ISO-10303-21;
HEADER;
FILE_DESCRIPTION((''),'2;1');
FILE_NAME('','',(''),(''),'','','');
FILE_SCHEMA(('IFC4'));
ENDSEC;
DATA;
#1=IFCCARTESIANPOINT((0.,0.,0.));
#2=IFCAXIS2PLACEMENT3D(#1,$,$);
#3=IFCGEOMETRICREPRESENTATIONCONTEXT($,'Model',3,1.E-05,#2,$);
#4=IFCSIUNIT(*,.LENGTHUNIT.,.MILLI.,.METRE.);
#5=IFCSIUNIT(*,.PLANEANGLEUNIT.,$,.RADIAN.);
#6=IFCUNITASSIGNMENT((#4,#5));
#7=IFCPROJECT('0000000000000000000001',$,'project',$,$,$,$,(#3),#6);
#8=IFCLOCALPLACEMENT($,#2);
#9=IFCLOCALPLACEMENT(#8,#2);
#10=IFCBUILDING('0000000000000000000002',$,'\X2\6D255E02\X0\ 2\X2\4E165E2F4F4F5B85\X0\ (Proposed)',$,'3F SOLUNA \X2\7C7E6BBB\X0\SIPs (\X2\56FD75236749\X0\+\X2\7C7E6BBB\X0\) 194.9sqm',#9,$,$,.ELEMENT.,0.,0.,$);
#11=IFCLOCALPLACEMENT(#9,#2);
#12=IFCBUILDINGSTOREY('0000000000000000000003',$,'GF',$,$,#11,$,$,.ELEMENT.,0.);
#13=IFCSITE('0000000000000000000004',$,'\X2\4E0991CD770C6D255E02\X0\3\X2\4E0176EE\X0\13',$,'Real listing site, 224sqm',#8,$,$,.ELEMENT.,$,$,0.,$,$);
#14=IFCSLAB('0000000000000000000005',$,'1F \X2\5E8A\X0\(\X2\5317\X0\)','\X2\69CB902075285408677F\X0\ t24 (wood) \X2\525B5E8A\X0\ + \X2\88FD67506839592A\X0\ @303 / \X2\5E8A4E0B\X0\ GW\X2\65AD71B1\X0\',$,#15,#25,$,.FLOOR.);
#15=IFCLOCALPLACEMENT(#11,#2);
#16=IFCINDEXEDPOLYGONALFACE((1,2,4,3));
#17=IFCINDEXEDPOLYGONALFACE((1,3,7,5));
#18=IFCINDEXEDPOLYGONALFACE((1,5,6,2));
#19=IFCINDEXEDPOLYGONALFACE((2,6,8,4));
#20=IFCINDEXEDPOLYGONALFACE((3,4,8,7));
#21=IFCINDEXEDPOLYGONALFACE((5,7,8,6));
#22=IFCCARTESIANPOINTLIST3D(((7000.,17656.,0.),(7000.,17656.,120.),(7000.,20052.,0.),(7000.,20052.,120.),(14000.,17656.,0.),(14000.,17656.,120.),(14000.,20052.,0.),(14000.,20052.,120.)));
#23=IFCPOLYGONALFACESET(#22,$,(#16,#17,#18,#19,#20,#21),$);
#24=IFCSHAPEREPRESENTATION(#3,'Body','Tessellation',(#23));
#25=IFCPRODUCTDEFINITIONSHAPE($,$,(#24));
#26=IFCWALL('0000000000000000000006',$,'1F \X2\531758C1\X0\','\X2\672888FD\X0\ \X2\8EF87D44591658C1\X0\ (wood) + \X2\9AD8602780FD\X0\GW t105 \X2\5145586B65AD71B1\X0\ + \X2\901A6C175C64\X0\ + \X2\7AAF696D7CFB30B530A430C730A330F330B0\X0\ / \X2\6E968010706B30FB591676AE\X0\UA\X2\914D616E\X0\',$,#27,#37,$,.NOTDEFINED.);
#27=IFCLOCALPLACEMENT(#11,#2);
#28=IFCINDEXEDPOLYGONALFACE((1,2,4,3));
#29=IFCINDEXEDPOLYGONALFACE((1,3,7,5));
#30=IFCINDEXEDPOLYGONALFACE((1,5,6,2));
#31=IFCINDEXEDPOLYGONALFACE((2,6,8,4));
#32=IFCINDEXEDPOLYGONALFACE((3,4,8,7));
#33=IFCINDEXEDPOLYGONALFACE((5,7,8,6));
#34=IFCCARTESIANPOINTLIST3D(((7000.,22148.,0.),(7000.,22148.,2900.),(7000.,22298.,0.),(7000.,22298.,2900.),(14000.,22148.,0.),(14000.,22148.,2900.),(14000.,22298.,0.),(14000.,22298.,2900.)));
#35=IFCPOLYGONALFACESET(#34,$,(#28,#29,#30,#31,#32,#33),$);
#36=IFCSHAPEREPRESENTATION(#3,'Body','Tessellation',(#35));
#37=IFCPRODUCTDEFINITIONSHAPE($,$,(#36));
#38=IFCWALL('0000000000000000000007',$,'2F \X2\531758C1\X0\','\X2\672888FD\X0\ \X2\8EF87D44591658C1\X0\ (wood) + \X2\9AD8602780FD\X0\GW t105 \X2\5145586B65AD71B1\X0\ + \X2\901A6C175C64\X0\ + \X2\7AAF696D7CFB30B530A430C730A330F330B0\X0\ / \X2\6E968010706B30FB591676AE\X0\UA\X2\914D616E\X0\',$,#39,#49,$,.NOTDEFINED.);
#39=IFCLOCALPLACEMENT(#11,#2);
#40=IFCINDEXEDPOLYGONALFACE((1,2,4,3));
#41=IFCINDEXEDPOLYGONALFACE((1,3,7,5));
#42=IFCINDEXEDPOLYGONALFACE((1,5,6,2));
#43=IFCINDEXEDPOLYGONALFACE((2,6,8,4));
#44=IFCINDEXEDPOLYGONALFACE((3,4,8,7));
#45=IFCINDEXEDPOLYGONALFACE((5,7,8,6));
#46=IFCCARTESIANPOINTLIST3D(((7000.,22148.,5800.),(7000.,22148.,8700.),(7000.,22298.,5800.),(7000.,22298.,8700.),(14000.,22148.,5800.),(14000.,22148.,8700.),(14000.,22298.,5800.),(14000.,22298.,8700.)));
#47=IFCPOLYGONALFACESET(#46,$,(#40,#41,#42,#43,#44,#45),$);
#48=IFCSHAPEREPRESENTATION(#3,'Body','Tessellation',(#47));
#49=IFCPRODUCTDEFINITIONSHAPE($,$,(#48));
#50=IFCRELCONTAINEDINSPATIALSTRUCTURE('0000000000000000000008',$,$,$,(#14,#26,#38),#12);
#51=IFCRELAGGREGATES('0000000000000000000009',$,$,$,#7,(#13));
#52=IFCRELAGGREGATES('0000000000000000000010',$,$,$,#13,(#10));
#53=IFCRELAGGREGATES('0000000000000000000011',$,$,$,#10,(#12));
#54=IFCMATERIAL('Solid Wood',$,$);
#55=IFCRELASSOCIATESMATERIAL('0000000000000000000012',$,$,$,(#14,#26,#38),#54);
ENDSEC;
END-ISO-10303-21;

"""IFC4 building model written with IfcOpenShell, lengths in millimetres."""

from ifc_helpers import new_model, si_unit, frame, frame_2d, origin, place, context, project, spatial, rectangle, extrude, material, element, save


model = new_model("IFC4")

# Units and contexts
model_context = context("Model", 3, precision=1e-05, world=origin())
ifc_project = project(units=[si_unit("LENGTHUNIT", "METRE", prefix="MILLI"), si_unit("PLANEANGLEUNIT", "RADIAN")], contexts=[model_context])

# Site, building, storey
site_placement = place(None, origin())
site = spatial("IfcSite", under=ifc_project, at=site_placement, Name="三重県津市3丁目13", ObjectType="Real listing site, 224sqm", CompositionType="ELEMENT", RefElevation=0.0)
building_placement = place(site_placement, origin())
building = spatial("IfcBuilding", under=site, at=building_placement, Name="津市 2世帯住宅 (Proposed)", ObjectType="3F SOLUNA 籾殻SIPs (国産杉+籾殻) 194.9sqm", CompositionType="ELEMENT", ElevationOfRefHeight=0.0, ElevationOfTerrain=0.0)
storey_placement = place(building_placement, origin())
storey = spatial("IfcBuildingStorey", under=building, at=storey_placement, Name="GF", CompositionType="ELEMENT", Elevation=0.0)

# Slab
ifc_material_1 = material(Name="Solid Wood")
slab_1_placement = place(storey_placement, frame((3500.0, 8828.0, 0.0)))
element("IfcSlab", 1, at=slab_1_placement, inside=storey, material=ifc_material_1, Name="1F 床(北)", Description="構造用合板 t24 (wood) 剛床 + 製材根太 @303 / 床下 GW断熱", PredefinedType="FLOOR", context=model_context, shape_type="SweptSolid", body=[
    extrude(rectangle(XDim=7000.0, YDim=2396.0, at=frame_2d((3500.0, 1198.0))), frame((3500.0, 8828.0, 0.0)), (0.0, 0.0, 1.0), 120.0),
])

# Wall
wall_1_placement = place(storey_placement, frame((3500.0, 11074.0, 0.0)))
element("IfcWall", 2, at=wall_1_placement, inside=storey, material=ifc_material_1, Name="1F 北壁", Description="木製 軸組外壁 (wood) + 高性能GW t105 充填断熱 + 通気層 + 窯業系サイディング / 準耐火・外皮UA配慮", PredefinedType="NOTDEFINED", context=model_context, shape_type="SweptSolid", body=[
    extrude(rectangle(XDim=7000.0, YDim=150.0, at=frame_2d((3500.0, 75.0))), frame((3500.0, 11074.0, 0.0)), (0.0, 0.0, 1.0), 2900.0),
])

# Wall
wall_2_placement = place(storey_placement, frame((3500.0, 11074.0, 2900.0)))
element("IfcWall", 3, at=wall_2_placement, inside=storey, material=ifc_material_1, Name="2F 北壁", Description="木製 軸組外壁 (wood) + 高性能GW t105 充填断熱 + 通気層 + 窯業系サイディング / 準耐火・外皮UA配慮", PredefinedType="NOTDEFINED", context=model_context, shape_type="SweptSolid", body=[
    extrude(rectangle(XDim=7000.0, YDim=150.0, at=frame_2d((3500.0, 75.0))), frame((3500.0, 11074.0, 2900.0)), (0.0, 0.0, 1.0), 2900.0),
])

save(model, "model.ifc")
